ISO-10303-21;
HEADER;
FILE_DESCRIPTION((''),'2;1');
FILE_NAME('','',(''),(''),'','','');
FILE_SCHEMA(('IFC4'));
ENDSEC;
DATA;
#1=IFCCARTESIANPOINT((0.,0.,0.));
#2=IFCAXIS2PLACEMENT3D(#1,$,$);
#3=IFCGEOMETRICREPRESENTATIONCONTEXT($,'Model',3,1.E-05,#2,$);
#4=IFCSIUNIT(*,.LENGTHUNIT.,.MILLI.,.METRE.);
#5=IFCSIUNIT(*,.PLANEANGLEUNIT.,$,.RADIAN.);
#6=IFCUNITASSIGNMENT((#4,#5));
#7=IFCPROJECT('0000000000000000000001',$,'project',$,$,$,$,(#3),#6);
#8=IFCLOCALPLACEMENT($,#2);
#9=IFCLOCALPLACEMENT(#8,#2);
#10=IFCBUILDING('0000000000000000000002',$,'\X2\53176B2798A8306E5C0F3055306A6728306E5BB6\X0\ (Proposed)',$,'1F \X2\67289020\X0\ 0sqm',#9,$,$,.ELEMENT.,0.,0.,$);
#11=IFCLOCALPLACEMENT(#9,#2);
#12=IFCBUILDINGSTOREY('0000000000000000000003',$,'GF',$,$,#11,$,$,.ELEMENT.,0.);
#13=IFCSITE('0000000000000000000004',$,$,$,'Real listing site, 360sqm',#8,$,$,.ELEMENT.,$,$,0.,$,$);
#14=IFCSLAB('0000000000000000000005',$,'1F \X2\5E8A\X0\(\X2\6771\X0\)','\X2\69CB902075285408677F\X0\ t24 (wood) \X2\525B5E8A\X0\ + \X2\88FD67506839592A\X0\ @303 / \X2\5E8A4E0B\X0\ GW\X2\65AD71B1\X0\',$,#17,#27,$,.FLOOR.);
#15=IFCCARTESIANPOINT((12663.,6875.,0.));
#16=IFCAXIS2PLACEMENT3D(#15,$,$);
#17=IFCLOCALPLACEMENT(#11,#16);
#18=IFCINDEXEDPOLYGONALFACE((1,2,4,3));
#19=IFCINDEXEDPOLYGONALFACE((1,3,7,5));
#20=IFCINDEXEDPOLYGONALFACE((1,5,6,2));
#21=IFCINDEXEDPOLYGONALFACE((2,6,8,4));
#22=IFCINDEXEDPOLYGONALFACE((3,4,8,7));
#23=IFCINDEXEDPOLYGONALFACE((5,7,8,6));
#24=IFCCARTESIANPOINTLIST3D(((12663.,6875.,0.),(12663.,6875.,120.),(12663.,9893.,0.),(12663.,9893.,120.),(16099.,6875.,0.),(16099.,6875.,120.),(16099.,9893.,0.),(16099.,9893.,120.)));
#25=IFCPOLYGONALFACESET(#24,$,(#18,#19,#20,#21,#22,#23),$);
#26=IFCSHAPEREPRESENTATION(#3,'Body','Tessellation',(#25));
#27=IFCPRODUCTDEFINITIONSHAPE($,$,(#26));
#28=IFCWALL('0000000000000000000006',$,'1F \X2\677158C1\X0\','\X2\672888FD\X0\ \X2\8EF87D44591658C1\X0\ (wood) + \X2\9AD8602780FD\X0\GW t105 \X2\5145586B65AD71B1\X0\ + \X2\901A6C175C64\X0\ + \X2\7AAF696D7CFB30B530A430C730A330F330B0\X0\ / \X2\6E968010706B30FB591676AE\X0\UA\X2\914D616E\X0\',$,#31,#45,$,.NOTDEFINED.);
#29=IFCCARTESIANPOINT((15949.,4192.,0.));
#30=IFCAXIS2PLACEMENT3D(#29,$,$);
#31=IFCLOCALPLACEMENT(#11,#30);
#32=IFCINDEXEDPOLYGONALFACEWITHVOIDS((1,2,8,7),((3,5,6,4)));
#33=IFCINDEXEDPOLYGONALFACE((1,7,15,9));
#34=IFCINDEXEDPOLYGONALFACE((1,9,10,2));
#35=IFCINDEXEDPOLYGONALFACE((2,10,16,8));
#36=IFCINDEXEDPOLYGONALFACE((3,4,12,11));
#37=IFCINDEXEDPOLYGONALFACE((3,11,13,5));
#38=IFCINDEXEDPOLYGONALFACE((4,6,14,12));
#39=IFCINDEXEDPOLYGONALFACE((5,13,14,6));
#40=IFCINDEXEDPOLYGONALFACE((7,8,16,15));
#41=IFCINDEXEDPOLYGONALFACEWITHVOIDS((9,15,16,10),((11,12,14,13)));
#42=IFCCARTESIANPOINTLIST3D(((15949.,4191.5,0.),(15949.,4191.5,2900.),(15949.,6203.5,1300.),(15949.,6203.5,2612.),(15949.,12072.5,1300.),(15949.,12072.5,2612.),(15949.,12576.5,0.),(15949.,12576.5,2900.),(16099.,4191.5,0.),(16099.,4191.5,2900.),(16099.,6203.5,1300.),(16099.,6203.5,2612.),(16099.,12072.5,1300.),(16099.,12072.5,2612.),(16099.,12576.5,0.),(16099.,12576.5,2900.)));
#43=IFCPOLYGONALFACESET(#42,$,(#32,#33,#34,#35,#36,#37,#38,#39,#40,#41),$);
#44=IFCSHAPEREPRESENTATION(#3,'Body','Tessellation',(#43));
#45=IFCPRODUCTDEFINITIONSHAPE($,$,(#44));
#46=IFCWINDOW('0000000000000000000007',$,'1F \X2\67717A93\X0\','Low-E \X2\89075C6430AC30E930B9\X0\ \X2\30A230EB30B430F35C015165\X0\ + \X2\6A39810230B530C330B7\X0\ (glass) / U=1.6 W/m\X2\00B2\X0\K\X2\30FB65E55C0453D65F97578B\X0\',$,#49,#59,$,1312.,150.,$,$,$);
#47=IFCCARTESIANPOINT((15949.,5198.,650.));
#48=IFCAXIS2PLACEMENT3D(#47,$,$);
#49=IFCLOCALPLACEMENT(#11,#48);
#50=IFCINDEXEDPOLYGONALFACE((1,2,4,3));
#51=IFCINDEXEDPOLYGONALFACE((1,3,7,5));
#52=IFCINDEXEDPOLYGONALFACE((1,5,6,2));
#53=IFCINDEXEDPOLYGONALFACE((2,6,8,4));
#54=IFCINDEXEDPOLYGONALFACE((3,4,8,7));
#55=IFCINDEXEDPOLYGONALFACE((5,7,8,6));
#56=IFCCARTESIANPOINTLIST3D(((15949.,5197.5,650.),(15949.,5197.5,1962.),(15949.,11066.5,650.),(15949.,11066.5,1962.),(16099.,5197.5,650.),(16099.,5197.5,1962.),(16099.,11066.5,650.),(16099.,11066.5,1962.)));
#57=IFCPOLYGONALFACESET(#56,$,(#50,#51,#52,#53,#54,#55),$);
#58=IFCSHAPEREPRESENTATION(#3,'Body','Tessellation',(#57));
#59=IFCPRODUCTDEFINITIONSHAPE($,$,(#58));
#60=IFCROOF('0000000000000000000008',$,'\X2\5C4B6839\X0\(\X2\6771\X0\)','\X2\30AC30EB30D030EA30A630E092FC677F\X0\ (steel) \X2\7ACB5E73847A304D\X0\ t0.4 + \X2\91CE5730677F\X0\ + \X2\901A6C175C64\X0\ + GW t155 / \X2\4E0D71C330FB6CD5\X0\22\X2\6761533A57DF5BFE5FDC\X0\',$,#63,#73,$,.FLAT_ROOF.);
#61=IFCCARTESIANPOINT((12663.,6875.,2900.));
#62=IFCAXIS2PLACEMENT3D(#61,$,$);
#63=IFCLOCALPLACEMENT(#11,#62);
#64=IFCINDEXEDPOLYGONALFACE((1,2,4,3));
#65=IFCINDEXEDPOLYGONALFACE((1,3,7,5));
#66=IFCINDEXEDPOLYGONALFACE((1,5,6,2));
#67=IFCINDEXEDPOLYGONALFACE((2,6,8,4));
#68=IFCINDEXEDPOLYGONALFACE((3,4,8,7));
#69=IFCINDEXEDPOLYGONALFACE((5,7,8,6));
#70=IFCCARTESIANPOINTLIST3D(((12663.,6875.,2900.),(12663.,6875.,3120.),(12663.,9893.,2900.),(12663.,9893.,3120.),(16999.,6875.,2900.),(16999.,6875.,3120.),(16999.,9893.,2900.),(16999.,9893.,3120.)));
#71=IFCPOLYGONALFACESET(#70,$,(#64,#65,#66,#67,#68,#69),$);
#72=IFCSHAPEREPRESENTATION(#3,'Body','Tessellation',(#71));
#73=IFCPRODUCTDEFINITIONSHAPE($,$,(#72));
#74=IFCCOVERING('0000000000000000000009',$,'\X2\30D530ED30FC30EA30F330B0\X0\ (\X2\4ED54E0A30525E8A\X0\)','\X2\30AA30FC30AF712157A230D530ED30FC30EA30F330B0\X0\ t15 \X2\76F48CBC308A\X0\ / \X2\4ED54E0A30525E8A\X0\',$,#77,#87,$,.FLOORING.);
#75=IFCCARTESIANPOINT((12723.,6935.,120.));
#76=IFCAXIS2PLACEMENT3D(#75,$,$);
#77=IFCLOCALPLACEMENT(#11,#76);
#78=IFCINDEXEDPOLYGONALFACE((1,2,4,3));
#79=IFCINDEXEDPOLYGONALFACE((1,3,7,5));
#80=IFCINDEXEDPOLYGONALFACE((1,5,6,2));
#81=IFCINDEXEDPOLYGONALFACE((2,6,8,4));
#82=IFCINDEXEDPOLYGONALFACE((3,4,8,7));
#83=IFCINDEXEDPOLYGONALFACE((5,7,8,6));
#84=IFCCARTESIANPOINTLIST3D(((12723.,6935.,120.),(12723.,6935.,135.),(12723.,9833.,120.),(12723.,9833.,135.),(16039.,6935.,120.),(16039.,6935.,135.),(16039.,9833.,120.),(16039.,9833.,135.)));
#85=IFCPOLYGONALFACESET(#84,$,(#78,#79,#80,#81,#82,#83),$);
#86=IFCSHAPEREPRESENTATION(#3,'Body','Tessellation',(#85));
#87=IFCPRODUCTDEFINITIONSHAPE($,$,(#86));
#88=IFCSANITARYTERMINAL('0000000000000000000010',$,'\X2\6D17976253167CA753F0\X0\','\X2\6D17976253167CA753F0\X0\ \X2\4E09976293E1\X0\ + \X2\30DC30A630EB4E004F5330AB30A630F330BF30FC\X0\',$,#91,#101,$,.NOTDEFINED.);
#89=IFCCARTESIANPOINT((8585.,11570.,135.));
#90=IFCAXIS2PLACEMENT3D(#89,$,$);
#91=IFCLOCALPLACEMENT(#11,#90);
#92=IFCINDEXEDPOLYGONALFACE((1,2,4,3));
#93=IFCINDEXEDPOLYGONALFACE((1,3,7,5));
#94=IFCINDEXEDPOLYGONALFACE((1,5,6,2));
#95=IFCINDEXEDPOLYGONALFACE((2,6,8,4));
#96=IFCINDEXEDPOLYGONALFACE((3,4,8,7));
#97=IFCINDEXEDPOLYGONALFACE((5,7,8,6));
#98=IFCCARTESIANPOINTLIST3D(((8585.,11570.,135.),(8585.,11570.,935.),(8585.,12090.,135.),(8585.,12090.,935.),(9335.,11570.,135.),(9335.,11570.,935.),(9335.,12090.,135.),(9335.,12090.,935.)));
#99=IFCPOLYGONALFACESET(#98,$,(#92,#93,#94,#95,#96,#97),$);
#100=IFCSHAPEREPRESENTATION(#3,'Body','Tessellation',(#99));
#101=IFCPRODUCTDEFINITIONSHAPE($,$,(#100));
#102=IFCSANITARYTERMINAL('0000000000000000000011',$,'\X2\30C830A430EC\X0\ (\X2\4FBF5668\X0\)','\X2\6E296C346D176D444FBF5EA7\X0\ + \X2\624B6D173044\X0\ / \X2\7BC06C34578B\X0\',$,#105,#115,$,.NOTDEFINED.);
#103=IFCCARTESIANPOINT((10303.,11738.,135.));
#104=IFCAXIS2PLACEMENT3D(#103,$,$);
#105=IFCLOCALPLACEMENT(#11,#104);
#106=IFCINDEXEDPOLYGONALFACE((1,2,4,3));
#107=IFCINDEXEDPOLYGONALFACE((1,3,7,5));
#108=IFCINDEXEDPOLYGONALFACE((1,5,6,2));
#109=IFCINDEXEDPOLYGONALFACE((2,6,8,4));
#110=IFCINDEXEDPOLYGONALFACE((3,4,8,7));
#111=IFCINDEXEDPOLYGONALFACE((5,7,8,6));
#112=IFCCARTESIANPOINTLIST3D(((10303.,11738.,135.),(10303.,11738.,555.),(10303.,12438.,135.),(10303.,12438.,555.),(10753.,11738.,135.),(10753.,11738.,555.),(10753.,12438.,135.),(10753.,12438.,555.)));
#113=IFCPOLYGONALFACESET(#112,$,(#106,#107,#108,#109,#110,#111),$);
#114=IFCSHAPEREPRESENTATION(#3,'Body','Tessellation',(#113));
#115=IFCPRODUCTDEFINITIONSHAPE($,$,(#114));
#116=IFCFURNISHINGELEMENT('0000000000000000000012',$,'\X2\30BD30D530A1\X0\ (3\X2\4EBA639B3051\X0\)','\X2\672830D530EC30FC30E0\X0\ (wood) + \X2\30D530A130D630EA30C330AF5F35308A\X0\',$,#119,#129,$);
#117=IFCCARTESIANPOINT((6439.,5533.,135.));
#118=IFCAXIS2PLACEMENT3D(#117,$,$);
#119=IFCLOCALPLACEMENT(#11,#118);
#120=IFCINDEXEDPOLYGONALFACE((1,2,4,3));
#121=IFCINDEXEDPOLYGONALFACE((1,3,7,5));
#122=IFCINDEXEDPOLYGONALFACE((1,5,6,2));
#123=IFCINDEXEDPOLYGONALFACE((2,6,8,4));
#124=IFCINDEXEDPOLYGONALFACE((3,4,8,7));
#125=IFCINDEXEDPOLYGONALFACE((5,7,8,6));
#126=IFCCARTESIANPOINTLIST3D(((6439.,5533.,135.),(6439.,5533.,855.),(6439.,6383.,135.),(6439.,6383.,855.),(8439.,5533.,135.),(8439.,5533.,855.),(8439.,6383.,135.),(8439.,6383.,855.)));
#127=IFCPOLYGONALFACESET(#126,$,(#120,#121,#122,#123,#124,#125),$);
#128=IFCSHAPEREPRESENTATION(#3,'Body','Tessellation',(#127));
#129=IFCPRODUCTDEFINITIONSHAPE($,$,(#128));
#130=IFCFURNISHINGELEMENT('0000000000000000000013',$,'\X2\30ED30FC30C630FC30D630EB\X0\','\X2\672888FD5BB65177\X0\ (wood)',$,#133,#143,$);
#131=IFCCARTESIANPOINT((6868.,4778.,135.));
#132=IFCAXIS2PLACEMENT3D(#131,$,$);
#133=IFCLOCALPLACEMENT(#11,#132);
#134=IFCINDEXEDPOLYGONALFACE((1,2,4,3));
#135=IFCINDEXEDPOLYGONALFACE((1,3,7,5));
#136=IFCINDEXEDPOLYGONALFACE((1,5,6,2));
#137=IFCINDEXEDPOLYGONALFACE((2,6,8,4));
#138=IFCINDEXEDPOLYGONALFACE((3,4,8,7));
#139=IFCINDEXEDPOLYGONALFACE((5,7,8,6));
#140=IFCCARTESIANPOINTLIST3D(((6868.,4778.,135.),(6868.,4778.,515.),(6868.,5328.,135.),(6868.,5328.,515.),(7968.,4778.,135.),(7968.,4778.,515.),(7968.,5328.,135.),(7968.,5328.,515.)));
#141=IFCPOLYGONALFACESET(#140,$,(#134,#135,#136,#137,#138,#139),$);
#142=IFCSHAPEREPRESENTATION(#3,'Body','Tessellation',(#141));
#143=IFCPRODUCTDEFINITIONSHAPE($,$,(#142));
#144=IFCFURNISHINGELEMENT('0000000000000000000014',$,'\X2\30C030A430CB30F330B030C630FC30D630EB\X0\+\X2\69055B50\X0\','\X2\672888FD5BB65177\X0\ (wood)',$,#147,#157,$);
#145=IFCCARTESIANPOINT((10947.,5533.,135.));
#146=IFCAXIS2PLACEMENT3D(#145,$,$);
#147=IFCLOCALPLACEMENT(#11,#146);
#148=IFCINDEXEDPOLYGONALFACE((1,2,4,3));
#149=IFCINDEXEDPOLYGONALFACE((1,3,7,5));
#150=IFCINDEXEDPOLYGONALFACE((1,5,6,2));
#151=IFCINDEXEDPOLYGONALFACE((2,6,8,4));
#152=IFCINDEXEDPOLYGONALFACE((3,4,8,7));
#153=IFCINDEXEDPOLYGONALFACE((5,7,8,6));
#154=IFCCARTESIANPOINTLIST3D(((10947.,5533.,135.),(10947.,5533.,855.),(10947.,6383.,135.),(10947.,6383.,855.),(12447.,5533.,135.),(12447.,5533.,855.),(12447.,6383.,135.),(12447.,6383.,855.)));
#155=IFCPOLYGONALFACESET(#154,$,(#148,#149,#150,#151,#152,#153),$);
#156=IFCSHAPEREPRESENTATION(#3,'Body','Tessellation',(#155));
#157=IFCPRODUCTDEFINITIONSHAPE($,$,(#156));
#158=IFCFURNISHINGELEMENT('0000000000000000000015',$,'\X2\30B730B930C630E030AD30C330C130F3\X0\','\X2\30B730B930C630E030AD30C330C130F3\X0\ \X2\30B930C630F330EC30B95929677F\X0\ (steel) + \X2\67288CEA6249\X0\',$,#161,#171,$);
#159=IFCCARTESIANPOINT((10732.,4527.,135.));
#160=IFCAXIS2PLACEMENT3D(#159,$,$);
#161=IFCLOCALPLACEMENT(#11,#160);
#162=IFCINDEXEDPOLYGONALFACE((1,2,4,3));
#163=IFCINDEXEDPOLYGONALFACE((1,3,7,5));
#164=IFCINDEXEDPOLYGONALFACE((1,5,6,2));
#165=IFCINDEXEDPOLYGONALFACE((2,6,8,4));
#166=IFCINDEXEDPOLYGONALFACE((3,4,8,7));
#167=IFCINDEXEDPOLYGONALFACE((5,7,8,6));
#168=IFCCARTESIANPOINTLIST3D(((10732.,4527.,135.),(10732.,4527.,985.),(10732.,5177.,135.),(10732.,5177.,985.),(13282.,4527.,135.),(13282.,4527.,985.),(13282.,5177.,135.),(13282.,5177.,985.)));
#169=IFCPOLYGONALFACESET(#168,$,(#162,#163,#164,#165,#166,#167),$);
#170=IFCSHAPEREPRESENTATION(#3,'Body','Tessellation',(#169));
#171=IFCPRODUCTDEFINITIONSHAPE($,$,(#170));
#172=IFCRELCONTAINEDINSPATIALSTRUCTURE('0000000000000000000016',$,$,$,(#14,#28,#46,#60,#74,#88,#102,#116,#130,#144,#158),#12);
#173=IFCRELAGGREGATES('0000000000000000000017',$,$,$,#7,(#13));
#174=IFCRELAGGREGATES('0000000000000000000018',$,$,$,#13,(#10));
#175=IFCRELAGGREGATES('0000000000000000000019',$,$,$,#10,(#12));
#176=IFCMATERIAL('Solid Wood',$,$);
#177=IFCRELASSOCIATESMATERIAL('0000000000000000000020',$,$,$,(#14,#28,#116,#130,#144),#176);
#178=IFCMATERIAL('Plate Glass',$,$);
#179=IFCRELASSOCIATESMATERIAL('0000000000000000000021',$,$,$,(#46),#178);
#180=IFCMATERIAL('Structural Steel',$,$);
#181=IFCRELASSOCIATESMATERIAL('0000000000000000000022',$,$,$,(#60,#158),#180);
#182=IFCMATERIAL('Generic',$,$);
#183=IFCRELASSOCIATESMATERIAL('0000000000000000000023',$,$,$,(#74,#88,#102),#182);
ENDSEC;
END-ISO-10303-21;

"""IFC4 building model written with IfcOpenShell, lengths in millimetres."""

from ifc_helpers import new_model, si_unit, frame, frame_2d, origin, place, context, project, spatial, rectangle, extrude, material, element, fill, save


model = new_model("IFC4")

# Units and contexts
model_context = context("Model", 3, precision=1e-05, world=origin())
ifc_project = project(units=[si_unit("LENGTHUNIT", "METRE", prefix="MILLI"), si_unit("PLANEANGLEUNIT", "RADIAN")], contexts=[model_context])

# Site, building, storey
site_placement = place(None, origin())
site = spatial("IfcSite", under=ifc_project, at=site_placement, ObjectType="Real listing site, 360sqm", CompositionType="ELEMENT", RefElevation=0.0)
building_placement = place(site_placement, origin())
building = spatial("IfcBuilding", under=site, at=building_placement, Name="北欧風の小さな木の家 (Proposed)", ObjectType="1F 木造 0sqm", CompositionType="ELEMENT", ElevationOfRefHeight=0.0, ElevationOfTerrain=0.0)
storey_placement = place(building_placement, origin())
storey = spatial("IfcBuildingStorey", under=building, at=storey_placement, Name="GF", CompositionType="ELEMENT", Elevation=0.0)

# Slab
ifc_material_1 = material(Name="Solid Wood")
slab_1_placement = place(storey_placement, frame((12663.0, 6875.0, 0.0)))
element("IfcSlab", 1, at=slab_1_placement, inside=storey, material=ifc_material_1, Name="1F 床(東)", Description="構造用合板 t24 (wood) 剛床 + 製材根太 @303 / 床下 GW断熱", PredefinedType="FLOOR", context=model_context, shape_type="SweptSolid", body=[
    extrude(rectangle(XDim=3436.0, YDim=3018.0, at=frame_2d((1718.0, 1509.0))), frame((12663.0, 6875.0, 0.0)), (0.0, 0.0, 1.0), 120.0),
])

# Wall, opening, window
wall_1_placement = place(storey_placement, frame((15949.0, 4192.0, 0.0)))
wall_1 = element("IfcWall", 2, at=wall_1_placement, inside=storey, material=ifc_material_1, Name="1F 東壁", Description="木製 軸組外壁 (wood) + 高性能GW t105 充填断熱 + 通気層 + 窯業系サイディング / 準耐火・外皮UA配慮", PredefinedType="NOTDEFINED", context=model_context, shape_type="SweptSolid", body=[
    extrude(rectangle(XDim=150.0, YDim=8385.0, at=frame_2d((75.0, 4192.0))), frame((15949.0, 4192.0, 0.0)), (0.0, 0.0, 1.0), 2900.0),
])
opening_1_placement = place(storey_placement, frame((15949.0, 5198.0, 650.0)))
opening_1 = element("IfcOpeningElement", 3, at=opening_1_placement, cuts=wall_1, PredefinedType="NOTDEFINED", context=model_context, shape_type="SweptSolid", body=[
    extrude(rectangle(XDim=150.0, YDim=5869.0, at=frame_2d((75.0, 2934.0))), frame((15949.0, 5198.0, 650.0)), (0.0, 0.0, 1.0), 1312.0),
])
ifc_material_2 = material(Name="Plate Glass")
window_1_placement = place(storey_placement, frame((15949.0, 5198.0, 650.0)))
window_1 = element("IfcWindow", 4, at=window_1_placement, inside=storey, material=ifc_material_2, Name="1F 東窓", Description="Low-E 複層ガラス アルゴン封入 + 樹脂サッシ (glass) / U=1.6 W/m²K・日射取得型", OverallHeight=1312.0, OverallWidth=150.0, context=model_context, shape_type="SweptSolid", body=[
    extrude(rectangle(XDim=150.0, YDim=5869.0, at=frame_2d((75.0, 2934.0))), frame((15949.0, 5198.0, 650.0)), (0.0, 0.0, 1.0), 1312.0),
])
fill(opening_1, window_1)

# Roof
ifc_material_3 = material(Name="Structural Steel")
roof_placement = place(storey_placement, frame((12663.0, 6875.0, 2900.0)))
element("IfcRoof", 5, at=roof_placement, inside=storey, material=ifc_material_3, Name="屋根(東)", Description="ガルバリウム鋼板 (steel) 立平葺き t0.4 + 野地板 + 通気層 + GW t155 / 不燃・法22条区域対応", PredefinedType="FLAT_ROOF", context=model_context, shape_type="SweptSolid", body=[
    extrude(rectangle(XDim=4336.0, YDim=3018.0, at=frame_2d((2168.0, 1509.0))), frame((12663.0, 6875.0, 2900.0)), (0.0, 0.0, 1.0), 220.0),
])

# Covering
ifc_material_4 = material(Name="Generic")
covering_placement = place(storey_placement, frame((12723.0, 6935.0, 120.0)))
element("IfcCovering", 6, at=covering_placement, inside=storey, material=ifc_material_4, Name="フローリング (仕上げ床)", Description="オーク無垢フローリング t15 直貼り / 仕上げ床", PredefinedType="FLOORING", context=model_context, shape_type="SweptSolid", body=[
    extrude(rectangle(XDim=3316.0, YDim=2898.0, at=frame_2d((1658.0, 1449.0))), frame((12723.0, 6935.0, 120.0)), (0.0, 0.0, 1.0), 15.0),
])

# Sanitary terminals
sanitary_terminal_1_placement = place(storey_placement, frame((8585.0, 11570.0, 135.0)))
element("IfcSanitaryTerminal", 7, at=sanitary_terminal_1_placement, inside=storey, material=ifc_material_4, Name="洗面化粧台", Description="洗面化粧台 三面鏡 + ボウル一体カウンター", PredefinedType="NOTDEFINED", context=model_context, shape_type="SweptSolid", body=[
    extrude(rectangle(XDim=750.0, YDim=520.0, at=frame_2d((375.0, 260.0))), frame((8585.0, 11570.0, 135.0)), (0.0, 0.0, 1.0), 800.0),
])
sanitary_terminal_2_placement = place(storey_placement, frame((10303.0, 11738.0, 135.0)))
element("IfcSanitaryTerminal", 8, at=sanitary_terminal_2_placement, inside=storey, material=ifc_material_4, Name="トイレ (便器)", Description="温水洗浄便座 + 手洗い / 節水型", PredefinedType="NOTDEFINED", context=model_context, shape_type="SweptSolid", body=[
    extrude(rectangle(XDim=450.0, YDim=700.0, at=frame_2d((225.0, 350.0))), frame((10303.0, 11738.0, 135.0)), (0.0, 0.0, 1.0), 420.0),
])

# Furnishing elements
furnishing_1_placement = place(storey_placement, frame((6439.0, 5533.0, 135.0)))
element("IfcFurnishingElement", 9, at=furnishing_1_placement, inside=storey, material=ifc_material_1, Name="ソファ (3人掛け)", Description="木フレーム (wood) + ファブリック張り", context=model_context, shape_type="SweptSolid", body=[
    extrude(rectangle(XDim=2000.0, YDim=850.0, at=frame_2d((1000.0, 425.0))), frame((6439.0, 5533.0, 135.0)), (0.0, 0.0, 1.0), 720.0),
])
furnishing_2_placement = place(storey_placement, frame((6868.0, 4778.0, 135.0)))
element("IfcFurnishingElement", 10, at=furnishing_2_placement, inside=storey, material=ifc_material_1, Name="ローテーブル", Description="木製家具 (wood)", context=model_context, shape_type="SweptSolid", body=[
    extrude(rectangle(XDim=1100.0, YDim=550.0, at=frame_2d((550.0, 275.0))), frame((6868.0, 4778.0, 135.0)), (0.0, 0.0, 1.0), 380.0),
])
furnishing_3_placement = place(storey_placement, frame((10947.0, 5533.0, 135.0)))
element("IfcFurnishingElement", 11, at=furnishing_3_placement, inside=storey, material=ifc_material_1, Name="ダイニングテーブル+椅子", Description="木製家具 (wood)", context=model_context, shape_type="SweptSolid", body=[
    extrude(rectangle(XDim=1500.0, YDim=850.0, at=frame_2d((750.0, 425.0))), frame((10947.0, 5533.0, 135.0)), (0.0, 0.0, 1.0), 720.0),
])
furnishing_4_placement = place(storey_placement, frame((10732.0, 4527.0, 135.0)))
element("IfcFurnishingElement", 12, at=furnishing_4_placement, inside=storey, material=ifc_material_3, Name="システムキッチン", Description="システムキッチン ステンレス天板 (steel) + 木質扉", context=model_context, shape_type="SweptSolid", body=[
    extrude(rectangle(XDim=2550.0, YDim=650.0, at=frame_2d((1275.0, 325.0))), frame((10732.0, 4527.0, 135.0)), (0.0, 0.0, 1.0), 850.0),
])

save(model, "model.ifc")
